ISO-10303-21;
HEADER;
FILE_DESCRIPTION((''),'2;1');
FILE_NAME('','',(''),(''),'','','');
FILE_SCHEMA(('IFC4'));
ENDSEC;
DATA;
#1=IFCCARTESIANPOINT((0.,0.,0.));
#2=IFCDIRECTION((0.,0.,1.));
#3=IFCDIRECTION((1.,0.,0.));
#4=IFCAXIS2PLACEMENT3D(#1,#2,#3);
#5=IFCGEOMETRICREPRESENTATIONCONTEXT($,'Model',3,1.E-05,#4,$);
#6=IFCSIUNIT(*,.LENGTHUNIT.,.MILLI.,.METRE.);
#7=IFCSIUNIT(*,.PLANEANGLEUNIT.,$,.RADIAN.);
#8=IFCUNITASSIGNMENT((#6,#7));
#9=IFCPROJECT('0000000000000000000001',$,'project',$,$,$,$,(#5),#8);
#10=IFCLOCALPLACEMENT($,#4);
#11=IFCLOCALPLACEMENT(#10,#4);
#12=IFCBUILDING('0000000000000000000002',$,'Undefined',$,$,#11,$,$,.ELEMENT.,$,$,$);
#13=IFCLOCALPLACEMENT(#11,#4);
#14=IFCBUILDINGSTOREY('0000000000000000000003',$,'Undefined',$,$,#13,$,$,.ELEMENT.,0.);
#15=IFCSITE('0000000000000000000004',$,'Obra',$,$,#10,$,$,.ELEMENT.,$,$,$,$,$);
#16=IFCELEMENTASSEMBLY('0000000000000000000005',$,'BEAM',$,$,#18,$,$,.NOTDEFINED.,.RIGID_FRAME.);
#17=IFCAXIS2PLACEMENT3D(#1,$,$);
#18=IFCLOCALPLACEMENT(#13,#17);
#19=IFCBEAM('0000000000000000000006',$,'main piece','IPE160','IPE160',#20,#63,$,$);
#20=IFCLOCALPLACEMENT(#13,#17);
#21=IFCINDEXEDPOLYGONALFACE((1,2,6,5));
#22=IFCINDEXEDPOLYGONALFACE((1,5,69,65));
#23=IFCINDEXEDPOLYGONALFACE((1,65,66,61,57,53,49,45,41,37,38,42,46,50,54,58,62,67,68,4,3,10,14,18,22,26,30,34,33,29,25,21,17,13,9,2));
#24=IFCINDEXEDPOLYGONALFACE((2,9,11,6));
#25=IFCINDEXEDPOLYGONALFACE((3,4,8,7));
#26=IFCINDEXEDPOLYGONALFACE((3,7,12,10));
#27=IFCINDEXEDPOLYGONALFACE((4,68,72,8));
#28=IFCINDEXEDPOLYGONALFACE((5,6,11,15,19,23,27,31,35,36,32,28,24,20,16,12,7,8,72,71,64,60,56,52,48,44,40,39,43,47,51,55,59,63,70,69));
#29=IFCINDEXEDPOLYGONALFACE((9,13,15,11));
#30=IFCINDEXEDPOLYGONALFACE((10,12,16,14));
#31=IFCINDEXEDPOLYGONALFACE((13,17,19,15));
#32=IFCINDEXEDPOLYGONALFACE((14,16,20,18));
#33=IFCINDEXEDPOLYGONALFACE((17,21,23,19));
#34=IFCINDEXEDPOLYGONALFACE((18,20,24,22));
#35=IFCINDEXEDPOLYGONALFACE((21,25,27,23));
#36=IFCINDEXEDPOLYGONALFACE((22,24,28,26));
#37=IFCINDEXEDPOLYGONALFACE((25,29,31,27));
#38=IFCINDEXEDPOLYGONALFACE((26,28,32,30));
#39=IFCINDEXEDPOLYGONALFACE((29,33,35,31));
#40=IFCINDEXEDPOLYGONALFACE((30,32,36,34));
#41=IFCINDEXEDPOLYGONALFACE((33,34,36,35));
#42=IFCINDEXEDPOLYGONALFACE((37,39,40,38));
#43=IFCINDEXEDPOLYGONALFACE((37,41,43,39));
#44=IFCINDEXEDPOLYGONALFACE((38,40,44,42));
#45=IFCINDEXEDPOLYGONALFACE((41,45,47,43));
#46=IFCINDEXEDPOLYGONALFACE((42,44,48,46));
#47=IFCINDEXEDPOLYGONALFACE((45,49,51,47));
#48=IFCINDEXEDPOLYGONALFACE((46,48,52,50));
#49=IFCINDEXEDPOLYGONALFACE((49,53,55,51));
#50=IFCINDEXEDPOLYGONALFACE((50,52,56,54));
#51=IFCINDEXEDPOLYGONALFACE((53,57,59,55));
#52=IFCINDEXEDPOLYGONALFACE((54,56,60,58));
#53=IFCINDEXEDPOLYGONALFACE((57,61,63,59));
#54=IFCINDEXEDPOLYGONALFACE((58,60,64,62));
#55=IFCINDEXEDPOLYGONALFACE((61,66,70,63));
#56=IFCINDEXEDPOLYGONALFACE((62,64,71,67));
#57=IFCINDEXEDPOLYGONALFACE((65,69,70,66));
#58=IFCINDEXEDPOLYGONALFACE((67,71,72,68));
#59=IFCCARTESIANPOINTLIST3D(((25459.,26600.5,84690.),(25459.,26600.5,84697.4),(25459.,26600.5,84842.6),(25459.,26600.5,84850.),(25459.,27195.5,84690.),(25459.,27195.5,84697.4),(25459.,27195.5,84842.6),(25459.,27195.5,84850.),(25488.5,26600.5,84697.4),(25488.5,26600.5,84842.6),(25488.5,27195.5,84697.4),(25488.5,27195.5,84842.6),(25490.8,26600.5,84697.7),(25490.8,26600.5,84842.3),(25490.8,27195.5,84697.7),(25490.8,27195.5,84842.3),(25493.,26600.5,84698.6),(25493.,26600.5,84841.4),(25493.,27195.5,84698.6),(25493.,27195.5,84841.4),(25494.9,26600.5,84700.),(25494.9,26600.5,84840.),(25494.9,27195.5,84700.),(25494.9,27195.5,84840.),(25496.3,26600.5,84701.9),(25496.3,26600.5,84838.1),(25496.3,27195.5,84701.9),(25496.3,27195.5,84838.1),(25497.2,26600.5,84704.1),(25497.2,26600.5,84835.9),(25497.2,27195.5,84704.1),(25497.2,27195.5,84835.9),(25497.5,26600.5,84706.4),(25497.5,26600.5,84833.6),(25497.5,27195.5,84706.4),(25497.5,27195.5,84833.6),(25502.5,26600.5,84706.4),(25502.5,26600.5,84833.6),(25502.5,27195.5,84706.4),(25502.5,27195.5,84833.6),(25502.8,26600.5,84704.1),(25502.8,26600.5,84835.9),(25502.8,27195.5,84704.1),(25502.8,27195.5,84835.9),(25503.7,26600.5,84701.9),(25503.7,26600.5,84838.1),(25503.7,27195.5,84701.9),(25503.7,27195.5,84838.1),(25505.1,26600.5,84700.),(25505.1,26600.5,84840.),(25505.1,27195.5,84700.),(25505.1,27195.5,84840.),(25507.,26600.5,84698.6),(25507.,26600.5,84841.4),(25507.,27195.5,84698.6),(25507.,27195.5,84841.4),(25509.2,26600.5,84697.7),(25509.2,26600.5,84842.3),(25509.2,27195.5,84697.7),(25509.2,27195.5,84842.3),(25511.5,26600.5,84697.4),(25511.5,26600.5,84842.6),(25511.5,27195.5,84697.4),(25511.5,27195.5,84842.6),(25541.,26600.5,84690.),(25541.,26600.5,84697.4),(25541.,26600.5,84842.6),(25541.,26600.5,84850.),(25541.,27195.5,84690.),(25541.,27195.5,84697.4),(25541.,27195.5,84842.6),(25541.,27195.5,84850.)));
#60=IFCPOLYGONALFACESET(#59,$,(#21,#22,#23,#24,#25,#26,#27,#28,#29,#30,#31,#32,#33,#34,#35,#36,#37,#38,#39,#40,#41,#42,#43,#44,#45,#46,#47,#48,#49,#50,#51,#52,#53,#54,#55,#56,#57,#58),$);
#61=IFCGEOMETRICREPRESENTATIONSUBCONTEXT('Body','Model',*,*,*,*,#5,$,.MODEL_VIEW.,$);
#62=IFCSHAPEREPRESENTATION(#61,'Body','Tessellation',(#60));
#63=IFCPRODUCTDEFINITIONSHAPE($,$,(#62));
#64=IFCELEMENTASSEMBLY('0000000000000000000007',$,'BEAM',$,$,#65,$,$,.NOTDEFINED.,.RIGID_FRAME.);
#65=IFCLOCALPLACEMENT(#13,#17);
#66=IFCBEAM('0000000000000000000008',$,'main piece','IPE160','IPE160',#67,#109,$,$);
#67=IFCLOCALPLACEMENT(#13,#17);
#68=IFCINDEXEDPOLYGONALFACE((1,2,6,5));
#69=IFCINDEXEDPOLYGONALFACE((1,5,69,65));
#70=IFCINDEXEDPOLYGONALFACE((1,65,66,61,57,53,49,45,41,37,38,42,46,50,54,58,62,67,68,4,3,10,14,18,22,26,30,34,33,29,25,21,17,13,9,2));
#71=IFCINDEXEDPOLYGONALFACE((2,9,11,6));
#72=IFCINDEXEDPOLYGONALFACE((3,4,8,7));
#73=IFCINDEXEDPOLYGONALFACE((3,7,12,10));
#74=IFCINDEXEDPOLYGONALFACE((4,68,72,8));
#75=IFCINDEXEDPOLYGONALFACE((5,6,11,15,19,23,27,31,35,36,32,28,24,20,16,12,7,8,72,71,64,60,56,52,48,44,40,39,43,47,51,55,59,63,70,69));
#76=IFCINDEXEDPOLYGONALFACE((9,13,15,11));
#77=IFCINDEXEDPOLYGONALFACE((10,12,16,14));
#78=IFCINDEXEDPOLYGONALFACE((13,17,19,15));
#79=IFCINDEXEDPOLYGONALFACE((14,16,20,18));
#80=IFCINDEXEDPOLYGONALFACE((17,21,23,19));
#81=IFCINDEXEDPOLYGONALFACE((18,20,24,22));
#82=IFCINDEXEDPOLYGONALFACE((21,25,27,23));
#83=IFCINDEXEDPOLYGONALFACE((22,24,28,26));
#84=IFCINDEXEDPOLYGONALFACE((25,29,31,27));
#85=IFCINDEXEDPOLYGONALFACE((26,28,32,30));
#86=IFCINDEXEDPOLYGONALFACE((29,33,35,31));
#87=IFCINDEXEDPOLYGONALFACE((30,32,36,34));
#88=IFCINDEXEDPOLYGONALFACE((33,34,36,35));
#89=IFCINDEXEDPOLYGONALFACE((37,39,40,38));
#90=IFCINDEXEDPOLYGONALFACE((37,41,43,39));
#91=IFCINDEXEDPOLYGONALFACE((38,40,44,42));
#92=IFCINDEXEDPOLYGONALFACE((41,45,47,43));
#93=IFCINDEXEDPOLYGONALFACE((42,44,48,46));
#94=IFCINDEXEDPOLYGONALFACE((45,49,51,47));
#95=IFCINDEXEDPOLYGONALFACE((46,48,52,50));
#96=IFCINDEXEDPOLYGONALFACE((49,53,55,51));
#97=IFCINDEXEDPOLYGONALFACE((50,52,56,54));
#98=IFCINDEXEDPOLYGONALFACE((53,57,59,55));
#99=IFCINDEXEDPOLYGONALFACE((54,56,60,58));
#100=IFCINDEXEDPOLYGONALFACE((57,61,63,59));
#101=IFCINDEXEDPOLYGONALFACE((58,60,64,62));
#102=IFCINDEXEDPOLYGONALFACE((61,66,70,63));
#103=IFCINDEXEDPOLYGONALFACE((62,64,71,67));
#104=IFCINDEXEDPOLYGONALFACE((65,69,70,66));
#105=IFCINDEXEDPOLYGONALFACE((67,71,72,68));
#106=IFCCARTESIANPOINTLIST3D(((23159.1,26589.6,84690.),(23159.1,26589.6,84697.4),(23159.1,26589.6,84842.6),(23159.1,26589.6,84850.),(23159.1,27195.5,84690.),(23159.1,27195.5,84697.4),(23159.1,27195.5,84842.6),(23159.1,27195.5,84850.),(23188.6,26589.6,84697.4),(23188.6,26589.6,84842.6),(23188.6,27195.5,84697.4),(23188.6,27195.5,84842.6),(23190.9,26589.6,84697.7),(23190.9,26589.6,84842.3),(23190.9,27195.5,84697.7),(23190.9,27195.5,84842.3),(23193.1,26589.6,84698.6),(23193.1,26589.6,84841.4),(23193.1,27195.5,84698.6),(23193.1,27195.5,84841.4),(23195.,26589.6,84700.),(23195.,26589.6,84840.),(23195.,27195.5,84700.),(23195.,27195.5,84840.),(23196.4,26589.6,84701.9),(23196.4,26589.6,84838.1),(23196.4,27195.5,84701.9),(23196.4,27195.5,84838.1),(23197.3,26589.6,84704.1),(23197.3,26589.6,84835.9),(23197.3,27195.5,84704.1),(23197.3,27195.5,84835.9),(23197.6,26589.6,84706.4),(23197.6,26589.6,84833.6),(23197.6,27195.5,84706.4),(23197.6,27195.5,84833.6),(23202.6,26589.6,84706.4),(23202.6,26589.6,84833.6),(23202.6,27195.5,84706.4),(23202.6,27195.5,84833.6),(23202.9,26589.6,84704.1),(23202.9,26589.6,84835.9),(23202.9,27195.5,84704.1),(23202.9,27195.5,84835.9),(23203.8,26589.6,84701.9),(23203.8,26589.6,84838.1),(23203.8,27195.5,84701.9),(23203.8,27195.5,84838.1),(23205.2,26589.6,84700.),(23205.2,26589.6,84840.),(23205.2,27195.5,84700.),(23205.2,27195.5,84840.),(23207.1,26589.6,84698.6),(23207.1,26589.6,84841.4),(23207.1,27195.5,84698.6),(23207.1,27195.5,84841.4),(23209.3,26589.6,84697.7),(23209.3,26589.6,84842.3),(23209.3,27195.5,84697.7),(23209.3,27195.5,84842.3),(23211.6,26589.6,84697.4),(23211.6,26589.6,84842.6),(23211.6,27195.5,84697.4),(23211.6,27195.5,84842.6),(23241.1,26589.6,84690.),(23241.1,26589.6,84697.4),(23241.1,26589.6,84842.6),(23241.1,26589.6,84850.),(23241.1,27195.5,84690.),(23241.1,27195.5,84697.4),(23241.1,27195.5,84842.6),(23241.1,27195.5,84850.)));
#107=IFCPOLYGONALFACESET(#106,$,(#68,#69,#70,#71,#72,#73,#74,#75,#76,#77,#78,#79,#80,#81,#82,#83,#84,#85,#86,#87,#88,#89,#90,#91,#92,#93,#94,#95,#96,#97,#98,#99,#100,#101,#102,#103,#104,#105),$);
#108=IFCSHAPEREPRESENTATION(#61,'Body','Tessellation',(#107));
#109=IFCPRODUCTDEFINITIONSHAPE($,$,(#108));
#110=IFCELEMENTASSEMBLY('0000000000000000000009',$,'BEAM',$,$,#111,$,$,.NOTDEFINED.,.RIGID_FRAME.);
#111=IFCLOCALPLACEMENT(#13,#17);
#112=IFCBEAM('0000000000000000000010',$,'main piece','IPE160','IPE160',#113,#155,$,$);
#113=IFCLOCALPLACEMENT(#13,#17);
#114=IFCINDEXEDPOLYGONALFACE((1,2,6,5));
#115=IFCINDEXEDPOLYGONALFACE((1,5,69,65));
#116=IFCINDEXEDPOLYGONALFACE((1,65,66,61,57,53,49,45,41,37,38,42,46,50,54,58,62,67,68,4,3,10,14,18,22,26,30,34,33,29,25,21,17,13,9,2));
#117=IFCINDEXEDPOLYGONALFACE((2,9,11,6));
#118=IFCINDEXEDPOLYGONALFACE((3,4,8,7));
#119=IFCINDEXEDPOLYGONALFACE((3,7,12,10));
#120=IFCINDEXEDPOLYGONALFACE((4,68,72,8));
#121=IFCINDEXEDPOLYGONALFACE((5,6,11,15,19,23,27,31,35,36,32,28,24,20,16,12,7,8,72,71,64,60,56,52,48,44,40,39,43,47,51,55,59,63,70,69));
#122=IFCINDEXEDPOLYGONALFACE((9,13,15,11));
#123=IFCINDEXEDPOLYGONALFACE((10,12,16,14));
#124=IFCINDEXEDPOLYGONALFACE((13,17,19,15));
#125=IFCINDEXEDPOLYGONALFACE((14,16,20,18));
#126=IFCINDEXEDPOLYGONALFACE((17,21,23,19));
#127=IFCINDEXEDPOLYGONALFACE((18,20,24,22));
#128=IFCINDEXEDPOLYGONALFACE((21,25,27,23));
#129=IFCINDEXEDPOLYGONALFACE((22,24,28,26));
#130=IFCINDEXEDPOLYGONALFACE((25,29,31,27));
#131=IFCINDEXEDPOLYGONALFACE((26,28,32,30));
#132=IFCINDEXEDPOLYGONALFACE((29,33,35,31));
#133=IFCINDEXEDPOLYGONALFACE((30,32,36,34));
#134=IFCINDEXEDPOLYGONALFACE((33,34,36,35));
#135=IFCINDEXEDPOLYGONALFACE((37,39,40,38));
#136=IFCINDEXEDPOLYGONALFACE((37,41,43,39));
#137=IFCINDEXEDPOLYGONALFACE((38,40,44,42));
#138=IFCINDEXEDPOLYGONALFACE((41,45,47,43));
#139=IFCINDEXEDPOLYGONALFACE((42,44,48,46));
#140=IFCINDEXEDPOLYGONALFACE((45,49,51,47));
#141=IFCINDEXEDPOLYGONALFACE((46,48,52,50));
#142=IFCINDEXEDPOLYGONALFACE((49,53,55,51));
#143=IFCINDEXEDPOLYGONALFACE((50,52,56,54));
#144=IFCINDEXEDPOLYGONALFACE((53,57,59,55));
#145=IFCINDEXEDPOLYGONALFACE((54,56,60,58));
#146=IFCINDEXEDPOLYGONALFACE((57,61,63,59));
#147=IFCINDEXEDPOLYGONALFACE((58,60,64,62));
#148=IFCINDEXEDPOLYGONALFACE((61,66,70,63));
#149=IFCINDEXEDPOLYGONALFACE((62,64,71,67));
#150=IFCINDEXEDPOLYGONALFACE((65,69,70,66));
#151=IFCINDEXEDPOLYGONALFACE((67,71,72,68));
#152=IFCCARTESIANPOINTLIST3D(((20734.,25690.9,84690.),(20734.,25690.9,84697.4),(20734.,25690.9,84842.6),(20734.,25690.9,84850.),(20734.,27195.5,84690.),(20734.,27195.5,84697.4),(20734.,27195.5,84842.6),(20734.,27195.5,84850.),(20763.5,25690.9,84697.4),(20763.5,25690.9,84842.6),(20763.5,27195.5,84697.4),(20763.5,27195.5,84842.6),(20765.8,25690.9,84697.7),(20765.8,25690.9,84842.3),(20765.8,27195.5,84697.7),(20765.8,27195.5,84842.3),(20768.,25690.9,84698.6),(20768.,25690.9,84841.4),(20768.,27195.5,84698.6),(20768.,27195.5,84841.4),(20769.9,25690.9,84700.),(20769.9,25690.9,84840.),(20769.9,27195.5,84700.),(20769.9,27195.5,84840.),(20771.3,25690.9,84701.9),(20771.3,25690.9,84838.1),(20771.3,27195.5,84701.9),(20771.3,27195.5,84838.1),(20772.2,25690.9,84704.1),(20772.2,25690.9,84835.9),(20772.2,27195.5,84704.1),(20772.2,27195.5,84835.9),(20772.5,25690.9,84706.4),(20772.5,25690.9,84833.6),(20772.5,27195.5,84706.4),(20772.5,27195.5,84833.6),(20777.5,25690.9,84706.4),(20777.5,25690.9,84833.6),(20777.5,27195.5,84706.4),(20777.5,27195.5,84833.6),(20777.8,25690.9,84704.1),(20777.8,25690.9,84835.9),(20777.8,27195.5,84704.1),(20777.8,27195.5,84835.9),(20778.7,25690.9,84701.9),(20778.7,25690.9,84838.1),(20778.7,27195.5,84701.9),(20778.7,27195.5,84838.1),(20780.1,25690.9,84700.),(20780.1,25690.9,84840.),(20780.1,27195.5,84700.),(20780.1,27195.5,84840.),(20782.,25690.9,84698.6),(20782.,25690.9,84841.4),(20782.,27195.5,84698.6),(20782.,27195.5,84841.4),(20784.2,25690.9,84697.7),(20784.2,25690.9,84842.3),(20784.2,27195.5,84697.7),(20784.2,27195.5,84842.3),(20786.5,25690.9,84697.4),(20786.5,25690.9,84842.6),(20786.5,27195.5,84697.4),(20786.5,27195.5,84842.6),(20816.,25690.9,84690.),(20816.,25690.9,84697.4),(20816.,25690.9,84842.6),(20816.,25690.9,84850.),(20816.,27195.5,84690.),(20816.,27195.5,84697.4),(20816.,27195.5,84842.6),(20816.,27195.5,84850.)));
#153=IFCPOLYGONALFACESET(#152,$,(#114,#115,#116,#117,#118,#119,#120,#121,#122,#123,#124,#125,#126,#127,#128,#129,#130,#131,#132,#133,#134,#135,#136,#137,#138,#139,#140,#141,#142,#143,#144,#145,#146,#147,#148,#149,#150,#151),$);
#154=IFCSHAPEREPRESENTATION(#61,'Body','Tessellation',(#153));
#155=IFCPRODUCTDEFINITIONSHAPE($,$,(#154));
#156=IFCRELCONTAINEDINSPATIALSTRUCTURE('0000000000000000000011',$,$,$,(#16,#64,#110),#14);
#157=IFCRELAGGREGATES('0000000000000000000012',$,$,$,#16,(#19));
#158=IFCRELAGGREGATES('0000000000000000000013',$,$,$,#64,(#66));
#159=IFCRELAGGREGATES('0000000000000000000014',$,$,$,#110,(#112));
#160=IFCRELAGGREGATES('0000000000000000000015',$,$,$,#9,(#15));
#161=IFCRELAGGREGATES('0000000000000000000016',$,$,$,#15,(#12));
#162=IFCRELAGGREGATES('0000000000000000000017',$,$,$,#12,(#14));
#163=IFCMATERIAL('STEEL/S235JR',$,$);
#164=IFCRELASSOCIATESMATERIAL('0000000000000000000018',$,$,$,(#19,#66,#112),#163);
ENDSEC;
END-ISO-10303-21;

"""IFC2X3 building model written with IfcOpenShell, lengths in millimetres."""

from ifc_helpers import new_model, si_unit, frame, origin_with_axes, origin_2d_with_axis, place, context, subcontext, project, spatial, i_section, extrude, material, element, aggregate, save


model = new_model("IFC2X3")

# Units and contexts
model_context = context("Model", 3, precision=1e-05, world=origin_with_axes())
body_context = subcontext(model_context, "Body", "Model", "MODEL_VIEW")
ifc_project = project(units=[si_unit("LENGTHUNIT", "METRE", prefix="MILLI"), si_unit("PLANEANGLEUNIT", "RADIAN")], contexts=[model_context])

# Site, building, storey
site_placement = place(None, origin_with_axes())
site = spatial("IfcSite", under=ifc_project, at=site_placement, Name="Obra", CompositionType="ELEMENT")
building_placement = place(site_placement, origin_with_axes())
building = spatial("IfcBuilding", under=site, at=building_placement, Name="Undefined", CompositionType="ELEMENT")
storey_placement = place(building_placement, origin_with_axes())
storey = spatial("IfcBuildingStorey", under=building, at=storey_placement, Name="Undefined", CompositionType="ELEMENT", Elevation=0.0)

# Element assemblies, beams
ifc_material_1 = material(Name="STEEL/S235JR")
assembly_1_placement = place(storey_placement, origin_with_axes())
assembly_1 = element("IfcElementAssembly", 1, at=assembly_1_placement, inside=storey, Name="BEAM", AssemblyPlace="NOTDEFINED", PredefinedType="RIGID_FRAME")
beam_1_placement = place(assembly_1_placement, frame((25500.0, 26600.5, 84770.0), z_axis=(0.0, 0.0, 1.0), x_axis=(0.0, 1.0, 0.0)))
beam_1 = element("IfcBeam", 2, at=beam_1_placement, material=ifc_material_1, Name="main piece", Description="IPE160", ObjectType="IPE160", context=body_context, shape_type="SweptSolid", body=[
    extrude(i_section(OverallWidth=82.0, OverallDepth=160.0, WebThickness=5.0, FlangeThickness=7.4, FilletRadius=9.0, at=origin_2d_with_axis()), frame((595.0, 0.0, 0.0), z_axis=(-1.0, 0.0, 0.0), x_axis=(0.0, -1.0, 0.0)), (0.0, 0.0, 1.0), 595.0),
])
aggregate(assembly_1, [beam_1])
assembly_2_placement = place(storey_placement, origin_with_axes())
assembly_2 = element("IfcElementAssembly", 3, at=assembly_2_placement, inside=storey, Name="BEAM", AssemblyPlace="NOTDEFINED", PredefinedType="RIGID_FRAME")
beam_2_placement = place(assembly_2_placement, frame((23200.1, 26589.6, 84770.0), z_axis=(0.0, 0.0, 1.0), x_axis=(0.0, 1.0, 0.0)))
beam_2 = element("IfcBeam", 4, at=beam_2_placement, material=ifc_material_1, Name="main piece", Description="IPE160", ObjectType="IPE160", context=body_context, shape_type="SweptSolid", body=[
    extrude(i_section(OverallWidth=82.0, OverallDepth=160.0, WebThickness=5.0, FlangeThickness=7.4, FilletRadius=9.0, at=origin_2d_with_axis()), frame((605.9, 0.0, 0.0), z_axis=(-1.0, 0.0, 0.0), x_axis=(0.0, -1.0, 0.0)), (0.0, 0.0, 1.0), 605.9),
])
aggregate(assembly_2, [beam_2])
assembly_3_placement = place(storey_placement, origin_with_axes())
assembly_3 = element("IfcElementAssembly", 5, at=assembly_3_placement, inside=storey, Name="BEAM", AssemblyPlace="NOTDEFINED", PredefinedType="RIGID_FRAME")
beam_3_placement = place(assembly_3_placement, frame((20775.0, 25690.9, 84770.0), z_axis=(0.0, 0.0, 1.0), x_axis=(0.0, 1.0, 0.0)))
beam_3 = element("IfcBeam", 6, at=beam_3_placement, material=ifc_material_1, Name="main piece", Description="IPE160", ObjectType="IPE160", context=body_context, shape_type="SweptSolid", body=[
    extrude(i_section(OverallWidth=82.0, OverallDepth=160.0, WebThickness=5.0, FlangeThickness=7.4, FilletRadius=9.0, at=origin_2d_with_axis()), frame((1504.6, 0.0, 0.0), z_axis=(-1.0, 0.0, 0.0), x_axis=(0.0, -1.0, 0.0)), (0.0, 0.0, 1.0), 1504.6),
])
aggregate(assembly_3, [beam_3])

save(model, "model.ifc")
